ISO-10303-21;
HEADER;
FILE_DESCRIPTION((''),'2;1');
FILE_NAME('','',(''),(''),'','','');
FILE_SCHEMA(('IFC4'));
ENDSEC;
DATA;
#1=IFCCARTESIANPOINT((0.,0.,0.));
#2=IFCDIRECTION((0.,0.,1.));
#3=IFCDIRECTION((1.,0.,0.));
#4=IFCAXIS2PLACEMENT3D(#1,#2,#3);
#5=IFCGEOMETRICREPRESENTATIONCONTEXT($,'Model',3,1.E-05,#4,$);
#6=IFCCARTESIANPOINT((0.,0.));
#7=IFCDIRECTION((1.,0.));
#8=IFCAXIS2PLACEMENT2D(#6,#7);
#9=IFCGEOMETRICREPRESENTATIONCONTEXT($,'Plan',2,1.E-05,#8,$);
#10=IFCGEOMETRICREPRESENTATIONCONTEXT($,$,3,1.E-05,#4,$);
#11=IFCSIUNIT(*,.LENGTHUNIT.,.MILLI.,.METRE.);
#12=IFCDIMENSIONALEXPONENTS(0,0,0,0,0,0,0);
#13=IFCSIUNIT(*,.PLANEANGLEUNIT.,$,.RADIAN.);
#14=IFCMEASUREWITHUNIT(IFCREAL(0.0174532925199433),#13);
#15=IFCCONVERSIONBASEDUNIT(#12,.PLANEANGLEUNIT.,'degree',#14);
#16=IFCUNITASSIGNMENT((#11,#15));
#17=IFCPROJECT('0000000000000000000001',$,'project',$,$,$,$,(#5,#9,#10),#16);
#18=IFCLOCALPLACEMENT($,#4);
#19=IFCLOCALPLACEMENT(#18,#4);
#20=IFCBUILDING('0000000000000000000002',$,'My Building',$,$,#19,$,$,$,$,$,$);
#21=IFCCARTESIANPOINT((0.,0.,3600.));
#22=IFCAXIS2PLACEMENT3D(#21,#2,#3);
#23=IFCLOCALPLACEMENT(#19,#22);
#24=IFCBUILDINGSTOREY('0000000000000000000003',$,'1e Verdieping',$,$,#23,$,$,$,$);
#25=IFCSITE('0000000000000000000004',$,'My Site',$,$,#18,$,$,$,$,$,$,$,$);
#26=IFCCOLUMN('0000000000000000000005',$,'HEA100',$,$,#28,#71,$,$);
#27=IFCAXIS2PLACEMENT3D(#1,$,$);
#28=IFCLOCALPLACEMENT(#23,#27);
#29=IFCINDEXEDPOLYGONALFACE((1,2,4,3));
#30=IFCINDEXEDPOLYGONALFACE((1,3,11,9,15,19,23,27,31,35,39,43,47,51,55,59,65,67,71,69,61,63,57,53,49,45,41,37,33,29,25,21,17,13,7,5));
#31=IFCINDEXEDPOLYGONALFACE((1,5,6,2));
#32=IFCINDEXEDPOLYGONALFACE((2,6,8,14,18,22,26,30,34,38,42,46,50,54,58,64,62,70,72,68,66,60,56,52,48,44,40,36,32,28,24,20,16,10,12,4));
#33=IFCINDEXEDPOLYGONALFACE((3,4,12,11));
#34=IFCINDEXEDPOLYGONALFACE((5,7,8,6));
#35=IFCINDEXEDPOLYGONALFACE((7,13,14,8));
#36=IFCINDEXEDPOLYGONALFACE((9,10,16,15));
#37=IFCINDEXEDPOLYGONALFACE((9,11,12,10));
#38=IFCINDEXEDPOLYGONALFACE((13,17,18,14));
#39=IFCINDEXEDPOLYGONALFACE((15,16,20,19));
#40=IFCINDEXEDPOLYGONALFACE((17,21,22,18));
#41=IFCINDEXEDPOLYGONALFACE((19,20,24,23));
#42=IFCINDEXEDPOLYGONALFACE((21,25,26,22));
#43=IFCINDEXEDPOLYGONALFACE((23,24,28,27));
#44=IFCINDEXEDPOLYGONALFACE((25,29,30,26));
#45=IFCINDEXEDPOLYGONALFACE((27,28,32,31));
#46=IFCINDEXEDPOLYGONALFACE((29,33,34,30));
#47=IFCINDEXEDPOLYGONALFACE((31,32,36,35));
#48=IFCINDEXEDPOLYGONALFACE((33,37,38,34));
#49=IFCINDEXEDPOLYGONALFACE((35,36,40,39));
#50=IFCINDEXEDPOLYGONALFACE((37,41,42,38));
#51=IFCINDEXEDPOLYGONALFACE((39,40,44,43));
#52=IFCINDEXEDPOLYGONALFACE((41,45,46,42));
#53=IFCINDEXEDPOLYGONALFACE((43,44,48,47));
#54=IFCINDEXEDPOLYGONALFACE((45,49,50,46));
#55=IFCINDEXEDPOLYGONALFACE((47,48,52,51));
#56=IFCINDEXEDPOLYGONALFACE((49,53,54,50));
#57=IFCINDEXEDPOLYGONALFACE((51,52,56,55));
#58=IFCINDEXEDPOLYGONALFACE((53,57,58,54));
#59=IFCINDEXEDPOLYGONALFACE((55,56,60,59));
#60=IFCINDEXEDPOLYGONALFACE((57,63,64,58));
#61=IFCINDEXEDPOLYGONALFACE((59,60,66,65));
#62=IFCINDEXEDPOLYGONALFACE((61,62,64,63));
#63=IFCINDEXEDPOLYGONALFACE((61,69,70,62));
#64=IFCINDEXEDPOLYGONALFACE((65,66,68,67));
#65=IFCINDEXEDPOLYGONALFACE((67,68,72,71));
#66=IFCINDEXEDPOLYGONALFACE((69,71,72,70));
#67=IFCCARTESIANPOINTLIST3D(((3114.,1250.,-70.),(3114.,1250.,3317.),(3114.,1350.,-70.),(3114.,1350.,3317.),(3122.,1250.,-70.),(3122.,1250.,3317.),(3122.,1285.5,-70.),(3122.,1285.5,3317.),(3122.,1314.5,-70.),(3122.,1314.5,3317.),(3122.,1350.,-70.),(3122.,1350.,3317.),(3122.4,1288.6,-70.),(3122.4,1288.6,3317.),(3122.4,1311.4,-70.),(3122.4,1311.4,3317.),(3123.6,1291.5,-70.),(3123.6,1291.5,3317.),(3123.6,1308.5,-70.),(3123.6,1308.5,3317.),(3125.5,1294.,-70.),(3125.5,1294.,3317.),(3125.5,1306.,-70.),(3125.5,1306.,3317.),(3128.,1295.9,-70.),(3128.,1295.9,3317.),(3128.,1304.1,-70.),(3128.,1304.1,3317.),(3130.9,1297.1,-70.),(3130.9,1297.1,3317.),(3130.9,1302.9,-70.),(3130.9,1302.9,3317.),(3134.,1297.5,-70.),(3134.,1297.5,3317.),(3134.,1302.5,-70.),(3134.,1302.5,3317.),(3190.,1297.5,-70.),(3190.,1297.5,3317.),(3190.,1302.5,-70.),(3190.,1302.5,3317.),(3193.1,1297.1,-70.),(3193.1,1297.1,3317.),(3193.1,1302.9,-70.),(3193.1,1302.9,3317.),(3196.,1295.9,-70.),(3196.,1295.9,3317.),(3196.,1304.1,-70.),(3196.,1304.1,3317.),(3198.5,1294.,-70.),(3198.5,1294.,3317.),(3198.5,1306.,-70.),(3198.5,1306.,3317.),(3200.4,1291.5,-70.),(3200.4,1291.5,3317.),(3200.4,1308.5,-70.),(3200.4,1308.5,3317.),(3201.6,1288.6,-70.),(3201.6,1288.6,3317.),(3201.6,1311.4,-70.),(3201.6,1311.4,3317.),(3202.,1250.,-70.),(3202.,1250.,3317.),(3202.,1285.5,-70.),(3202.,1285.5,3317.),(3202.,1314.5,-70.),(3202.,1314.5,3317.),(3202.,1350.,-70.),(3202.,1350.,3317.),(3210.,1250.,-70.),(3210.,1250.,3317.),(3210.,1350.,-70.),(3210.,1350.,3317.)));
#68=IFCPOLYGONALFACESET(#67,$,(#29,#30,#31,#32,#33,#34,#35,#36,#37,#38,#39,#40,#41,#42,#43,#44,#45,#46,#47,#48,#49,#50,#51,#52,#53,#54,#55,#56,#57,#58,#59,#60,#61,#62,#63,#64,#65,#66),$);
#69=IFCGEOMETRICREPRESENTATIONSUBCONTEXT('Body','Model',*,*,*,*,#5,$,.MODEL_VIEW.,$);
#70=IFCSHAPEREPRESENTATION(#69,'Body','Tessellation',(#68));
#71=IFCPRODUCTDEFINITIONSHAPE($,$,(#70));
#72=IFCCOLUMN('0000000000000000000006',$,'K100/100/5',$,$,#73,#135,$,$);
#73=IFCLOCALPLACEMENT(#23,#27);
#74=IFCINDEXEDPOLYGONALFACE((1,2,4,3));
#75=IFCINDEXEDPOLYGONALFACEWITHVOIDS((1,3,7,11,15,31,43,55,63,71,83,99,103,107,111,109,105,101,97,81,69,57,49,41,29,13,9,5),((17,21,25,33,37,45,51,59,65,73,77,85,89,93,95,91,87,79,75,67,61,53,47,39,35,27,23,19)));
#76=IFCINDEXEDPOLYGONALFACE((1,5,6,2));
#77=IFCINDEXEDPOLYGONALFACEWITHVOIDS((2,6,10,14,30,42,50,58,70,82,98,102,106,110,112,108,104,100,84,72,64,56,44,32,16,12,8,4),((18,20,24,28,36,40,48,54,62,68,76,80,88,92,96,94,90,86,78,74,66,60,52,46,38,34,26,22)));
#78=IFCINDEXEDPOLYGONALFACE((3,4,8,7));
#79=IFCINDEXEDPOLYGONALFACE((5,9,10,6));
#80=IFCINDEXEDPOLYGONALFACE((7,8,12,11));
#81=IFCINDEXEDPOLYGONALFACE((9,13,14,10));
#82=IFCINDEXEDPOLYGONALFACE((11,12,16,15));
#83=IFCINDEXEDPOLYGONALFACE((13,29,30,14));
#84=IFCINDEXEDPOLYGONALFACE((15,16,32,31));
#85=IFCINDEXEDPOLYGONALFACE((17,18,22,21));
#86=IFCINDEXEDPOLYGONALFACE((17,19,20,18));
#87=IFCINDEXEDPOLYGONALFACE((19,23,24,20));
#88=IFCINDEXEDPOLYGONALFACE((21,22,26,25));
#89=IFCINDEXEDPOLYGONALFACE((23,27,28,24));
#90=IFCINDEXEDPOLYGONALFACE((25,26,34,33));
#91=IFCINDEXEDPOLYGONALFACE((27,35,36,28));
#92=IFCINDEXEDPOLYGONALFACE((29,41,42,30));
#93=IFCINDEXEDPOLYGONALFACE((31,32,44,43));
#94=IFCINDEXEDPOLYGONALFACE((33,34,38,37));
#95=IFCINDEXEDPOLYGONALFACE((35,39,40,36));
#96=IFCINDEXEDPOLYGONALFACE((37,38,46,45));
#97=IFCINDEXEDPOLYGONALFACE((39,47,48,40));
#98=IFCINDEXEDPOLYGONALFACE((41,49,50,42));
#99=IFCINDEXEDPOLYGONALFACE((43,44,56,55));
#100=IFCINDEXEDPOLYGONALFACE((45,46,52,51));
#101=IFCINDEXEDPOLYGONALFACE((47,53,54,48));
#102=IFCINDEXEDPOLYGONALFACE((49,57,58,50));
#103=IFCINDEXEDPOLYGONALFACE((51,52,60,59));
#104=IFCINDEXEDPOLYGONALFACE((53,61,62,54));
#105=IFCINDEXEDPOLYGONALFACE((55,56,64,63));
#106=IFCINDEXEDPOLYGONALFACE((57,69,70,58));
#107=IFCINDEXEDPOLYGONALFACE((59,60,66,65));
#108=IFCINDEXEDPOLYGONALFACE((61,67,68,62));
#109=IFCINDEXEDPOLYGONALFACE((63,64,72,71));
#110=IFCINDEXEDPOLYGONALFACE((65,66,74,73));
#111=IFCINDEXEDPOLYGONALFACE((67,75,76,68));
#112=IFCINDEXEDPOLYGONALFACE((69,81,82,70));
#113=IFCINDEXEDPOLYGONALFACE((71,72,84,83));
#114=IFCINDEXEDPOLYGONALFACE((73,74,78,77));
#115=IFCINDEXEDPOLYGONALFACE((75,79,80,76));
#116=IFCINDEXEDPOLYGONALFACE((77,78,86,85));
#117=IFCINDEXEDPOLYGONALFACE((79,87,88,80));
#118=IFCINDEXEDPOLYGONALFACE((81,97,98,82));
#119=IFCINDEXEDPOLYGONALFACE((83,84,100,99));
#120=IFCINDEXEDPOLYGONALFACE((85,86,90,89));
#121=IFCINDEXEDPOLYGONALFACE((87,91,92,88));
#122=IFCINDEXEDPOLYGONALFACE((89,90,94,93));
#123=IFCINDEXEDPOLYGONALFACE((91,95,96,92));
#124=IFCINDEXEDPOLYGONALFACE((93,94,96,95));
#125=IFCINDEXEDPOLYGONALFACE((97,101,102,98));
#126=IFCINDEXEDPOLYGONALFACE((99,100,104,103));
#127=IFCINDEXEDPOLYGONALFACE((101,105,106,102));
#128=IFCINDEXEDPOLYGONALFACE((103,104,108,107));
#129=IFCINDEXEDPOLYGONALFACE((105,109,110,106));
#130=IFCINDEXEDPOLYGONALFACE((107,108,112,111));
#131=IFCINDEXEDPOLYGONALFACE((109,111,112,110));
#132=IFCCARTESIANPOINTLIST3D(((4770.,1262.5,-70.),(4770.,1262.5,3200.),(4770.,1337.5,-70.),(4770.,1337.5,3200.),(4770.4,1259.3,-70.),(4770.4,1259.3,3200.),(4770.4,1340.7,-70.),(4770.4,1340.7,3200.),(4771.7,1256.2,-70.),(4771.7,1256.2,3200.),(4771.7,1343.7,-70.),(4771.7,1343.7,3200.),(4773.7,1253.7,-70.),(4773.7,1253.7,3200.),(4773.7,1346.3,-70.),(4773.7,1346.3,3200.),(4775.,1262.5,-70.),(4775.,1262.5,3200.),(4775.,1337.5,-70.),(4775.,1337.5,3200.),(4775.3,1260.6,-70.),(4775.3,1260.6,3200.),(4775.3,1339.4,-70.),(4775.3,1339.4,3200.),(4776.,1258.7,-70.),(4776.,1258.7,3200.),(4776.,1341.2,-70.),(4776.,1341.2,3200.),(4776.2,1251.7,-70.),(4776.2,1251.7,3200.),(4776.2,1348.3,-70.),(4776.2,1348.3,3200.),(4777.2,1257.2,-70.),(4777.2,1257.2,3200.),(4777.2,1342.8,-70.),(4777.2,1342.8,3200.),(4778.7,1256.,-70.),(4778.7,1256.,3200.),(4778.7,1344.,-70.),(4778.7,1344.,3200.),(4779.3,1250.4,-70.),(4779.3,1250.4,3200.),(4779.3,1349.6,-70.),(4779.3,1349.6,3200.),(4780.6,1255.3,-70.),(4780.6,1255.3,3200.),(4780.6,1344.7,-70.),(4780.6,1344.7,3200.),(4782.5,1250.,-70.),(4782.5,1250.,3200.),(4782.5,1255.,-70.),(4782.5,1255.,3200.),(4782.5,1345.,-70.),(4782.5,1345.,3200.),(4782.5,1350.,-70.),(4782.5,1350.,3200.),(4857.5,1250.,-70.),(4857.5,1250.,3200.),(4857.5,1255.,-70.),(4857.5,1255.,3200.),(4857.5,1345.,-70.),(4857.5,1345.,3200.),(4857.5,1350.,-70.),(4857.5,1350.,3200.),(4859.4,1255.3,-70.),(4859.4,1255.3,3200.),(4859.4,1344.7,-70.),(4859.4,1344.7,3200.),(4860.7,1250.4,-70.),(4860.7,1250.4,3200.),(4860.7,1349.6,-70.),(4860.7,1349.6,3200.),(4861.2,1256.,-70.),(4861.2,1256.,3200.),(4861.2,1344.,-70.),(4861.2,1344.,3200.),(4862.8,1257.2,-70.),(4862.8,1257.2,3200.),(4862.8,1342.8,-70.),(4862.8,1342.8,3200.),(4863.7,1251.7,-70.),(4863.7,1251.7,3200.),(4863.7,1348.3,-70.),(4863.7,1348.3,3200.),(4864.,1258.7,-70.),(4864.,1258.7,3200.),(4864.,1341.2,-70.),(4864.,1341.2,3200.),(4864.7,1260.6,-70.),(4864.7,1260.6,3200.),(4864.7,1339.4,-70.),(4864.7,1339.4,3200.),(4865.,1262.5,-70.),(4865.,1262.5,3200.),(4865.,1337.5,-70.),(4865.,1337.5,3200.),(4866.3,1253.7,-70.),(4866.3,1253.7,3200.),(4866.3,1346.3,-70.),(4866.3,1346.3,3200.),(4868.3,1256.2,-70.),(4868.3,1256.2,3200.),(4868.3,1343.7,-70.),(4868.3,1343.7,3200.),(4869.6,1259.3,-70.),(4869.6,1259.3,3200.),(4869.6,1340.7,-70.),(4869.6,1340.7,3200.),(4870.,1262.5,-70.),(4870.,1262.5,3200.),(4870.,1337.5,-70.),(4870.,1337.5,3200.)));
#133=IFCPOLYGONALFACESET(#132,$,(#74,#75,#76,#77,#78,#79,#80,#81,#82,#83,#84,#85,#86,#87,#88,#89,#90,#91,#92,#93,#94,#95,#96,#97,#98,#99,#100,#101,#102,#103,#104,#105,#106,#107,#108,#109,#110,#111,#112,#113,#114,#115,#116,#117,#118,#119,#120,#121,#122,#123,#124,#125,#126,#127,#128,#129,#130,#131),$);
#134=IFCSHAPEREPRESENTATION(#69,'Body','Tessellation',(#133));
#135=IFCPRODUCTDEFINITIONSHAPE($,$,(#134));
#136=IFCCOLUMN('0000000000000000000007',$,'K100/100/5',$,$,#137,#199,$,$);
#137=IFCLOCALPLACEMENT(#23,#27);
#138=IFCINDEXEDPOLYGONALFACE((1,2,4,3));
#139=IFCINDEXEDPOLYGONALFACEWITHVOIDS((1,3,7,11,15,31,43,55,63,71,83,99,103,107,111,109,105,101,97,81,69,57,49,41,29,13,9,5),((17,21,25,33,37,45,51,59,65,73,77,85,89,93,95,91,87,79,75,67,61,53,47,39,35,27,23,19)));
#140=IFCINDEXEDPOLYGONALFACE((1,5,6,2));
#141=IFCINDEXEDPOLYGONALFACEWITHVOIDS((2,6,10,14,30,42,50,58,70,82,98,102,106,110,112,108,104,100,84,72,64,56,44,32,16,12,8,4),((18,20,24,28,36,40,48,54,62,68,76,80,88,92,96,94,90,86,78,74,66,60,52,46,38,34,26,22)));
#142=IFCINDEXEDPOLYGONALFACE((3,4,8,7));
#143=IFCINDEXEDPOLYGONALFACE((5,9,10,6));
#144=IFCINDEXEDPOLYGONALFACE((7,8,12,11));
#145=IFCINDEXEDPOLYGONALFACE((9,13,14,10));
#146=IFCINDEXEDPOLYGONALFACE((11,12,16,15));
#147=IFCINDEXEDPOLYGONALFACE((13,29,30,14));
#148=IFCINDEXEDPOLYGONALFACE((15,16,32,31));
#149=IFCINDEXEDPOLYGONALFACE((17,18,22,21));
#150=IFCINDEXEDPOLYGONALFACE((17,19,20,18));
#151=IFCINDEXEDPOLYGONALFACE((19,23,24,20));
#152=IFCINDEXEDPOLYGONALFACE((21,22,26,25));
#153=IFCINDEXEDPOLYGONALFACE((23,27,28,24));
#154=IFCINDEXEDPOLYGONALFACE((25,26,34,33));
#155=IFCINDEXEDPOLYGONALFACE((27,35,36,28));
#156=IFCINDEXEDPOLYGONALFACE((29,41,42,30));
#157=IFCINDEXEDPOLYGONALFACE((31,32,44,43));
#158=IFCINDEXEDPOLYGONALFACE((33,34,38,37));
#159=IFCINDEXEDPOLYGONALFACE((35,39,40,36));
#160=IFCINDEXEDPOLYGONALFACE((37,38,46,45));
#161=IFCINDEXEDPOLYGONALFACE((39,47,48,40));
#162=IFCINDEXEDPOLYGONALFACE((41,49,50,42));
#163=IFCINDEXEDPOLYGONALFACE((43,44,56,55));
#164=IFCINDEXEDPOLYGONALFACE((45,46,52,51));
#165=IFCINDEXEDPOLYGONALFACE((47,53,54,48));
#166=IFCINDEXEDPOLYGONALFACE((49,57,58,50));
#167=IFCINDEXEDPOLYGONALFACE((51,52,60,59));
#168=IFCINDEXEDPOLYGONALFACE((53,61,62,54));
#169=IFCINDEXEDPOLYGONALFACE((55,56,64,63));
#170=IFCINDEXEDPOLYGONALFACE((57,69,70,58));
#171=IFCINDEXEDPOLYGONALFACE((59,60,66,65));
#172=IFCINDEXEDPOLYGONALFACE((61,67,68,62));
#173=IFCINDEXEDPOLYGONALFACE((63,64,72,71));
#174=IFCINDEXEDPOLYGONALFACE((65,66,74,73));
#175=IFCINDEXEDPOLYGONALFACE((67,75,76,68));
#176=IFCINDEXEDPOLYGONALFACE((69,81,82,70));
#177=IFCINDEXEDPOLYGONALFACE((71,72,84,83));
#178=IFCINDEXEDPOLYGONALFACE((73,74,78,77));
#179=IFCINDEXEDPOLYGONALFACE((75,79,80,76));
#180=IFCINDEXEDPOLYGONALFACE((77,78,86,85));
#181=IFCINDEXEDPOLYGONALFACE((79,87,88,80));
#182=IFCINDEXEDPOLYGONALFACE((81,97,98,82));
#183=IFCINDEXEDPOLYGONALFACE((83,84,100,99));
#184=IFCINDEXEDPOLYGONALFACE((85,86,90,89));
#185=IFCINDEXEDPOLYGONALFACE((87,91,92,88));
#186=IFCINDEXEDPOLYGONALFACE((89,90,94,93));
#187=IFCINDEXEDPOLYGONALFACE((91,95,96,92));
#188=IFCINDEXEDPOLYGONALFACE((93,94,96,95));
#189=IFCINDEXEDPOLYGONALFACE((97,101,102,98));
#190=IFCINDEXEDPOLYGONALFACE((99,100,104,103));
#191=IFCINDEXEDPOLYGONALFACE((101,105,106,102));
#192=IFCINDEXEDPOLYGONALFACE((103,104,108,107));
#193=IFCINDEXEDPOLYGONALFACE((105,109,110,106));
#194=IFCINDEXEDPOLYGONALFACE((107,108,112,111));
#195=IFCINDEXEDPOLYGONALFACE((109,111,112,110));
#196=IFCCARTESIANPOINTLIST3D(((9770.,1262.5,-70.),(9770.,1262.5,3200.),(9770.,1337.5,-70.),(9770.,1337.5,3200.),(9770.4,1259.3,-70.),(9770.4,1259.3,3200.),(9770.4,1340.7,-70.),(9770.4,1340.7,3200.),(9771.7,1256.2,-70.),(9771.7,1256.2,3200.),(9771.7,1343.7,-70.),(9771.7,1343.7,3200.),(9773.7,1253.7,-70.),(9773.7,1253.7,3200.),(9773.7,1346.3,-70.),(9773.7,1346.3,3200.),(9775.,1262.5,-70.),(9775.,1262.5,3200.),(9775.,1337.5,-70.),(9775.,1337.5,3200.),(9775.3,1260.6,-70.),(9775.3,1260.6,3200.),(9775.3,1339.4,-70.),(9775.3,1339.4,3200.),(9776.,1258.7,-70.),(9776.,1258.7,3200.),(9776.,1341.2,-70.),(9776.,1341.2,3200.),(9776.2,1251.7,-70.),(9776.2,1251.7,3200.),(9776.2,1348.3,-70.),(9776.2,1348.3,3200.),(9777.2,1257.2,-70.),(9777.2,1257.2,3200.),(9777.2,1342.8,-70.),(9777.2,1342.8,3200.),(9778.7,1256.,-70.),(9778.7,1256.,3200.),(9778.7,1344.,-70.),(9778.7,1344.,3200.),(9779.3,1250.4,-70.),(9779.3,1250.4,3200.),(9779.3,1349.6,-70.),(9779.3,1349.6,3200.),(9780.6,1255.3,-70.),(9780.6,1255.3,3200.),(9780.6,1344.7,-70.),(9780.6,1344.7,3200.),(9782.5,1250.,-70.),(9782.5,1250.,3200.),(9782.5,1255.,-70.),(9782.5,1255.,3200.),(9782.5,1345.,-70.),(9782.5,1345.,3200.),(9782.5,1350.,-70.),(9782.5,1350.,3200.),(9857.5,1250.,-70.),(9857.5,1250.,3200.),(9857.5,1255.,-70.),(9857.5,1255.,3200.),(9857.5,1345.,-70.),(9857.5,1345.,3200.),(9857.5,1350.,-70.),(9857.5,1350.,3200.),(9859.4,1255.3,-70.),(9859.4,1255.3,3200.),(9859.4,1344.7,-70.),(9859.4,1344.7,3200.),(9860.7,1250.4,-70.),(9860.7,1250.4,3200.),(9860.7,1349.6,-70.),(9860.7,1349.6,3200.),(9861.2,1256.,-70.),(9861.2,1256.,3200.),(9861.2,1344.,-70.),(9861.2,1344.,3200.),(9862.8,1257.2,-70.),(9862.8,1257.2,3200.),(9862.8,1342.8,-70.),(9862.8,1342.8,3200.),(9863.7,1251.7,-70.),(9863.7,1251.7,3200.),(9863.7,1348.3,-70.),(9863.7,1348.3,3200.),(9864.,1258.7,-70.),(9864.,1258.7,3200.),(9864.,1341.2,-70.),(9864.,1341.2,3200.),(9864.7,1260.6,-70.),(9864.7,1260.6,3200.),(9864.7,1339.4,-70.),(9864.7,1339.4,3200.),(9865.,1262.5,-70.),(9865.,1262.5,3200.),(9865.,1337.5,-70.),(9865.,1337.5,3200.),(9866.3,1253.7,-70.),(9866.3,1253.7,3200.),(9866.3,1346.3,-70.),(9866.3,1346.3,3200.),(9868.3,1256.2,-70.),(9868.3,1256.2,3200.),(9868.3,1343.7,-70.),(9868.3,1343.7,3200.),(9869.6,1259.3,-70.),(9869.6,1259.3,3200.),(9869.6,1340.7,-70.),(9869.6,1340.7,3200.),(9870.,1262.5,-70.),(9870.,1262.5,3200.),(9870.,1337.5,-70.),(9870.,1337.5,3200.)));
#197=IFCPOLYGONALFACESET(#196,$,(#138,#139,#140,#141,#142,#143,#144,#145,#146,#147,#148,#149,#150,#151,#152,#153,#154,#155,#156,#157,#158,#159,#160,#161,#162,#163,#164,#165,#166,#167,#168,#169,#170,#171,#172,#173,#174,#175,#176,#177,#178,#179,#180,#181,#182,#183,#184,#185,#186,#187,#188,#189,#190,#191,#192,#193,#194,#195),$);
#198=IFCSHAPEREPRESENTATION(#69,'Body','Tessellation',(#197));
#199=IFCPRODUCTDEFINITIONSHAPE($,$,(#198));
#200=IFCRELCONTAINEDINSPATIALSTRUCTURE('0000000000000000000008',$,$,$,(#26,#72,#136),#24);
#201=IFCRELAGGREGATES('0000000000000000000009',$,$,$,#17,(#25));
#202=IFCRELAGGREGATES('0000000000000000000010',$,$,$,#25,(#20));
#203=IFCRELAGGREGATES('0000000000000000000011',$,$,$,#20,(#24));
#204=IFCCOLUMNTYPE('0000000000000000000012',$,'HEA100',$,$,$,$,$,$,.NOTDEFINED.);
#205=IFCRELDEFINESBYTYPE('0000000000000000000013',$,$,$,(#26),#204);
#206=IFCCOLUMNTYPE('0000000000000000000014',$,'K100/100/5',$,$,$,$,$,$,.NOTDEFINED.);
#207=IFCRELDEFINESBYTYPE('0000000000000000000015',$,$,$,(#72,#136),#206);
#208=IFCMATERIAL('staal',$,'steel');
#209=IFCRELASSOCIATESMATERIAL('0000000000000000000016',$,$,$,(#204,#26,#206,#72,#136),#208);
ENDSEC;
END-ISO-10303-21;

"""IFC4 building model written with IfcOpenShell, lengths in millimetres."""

from ifc_helpers import new_model, entity, si_unit, converted_unit, frame, origin_with_axes, origin_2d_with_axis, place, context, subcontext, project, spatial, hollow_rectangle, i_section, extrude, material, material_profile, profile_set, profile_usage, type_object, element, save


model = new_model("IFC4")

# Units and contexts
model_context = context("Model", 3, precision=1e-05, world=origin_with_axes())
plan_context = context("Plan", 2, precision=1e-05, world=origin_2d_with_axis())
context_of_model = context(None, 3, precision=1e-05, world=origin_with_axes())
body_context = subcontext(model_context, "Body", "Model", "MODEL_VIEW")
ifc_project = project(units=[si_unit("LENGTHUNIT", "METRE", prefix="MILLI"), converted_unit("PLANEANGLEUNIT", "degree", entity("IfcReal", 0.0174532925199433), si_unit("PLANEANGLEUNIT", "RADIAN"), dimensions=[0, 0, 0, 0, 0, 0, 0])], contexts=[model_context, plan_context, context_of_model])

# Site, building, storey
site_placement = place(None, origin_with_axes())
site = spatial("IfcSite", under=ifc_project, at=site_placement, Name="My Site")
building_placement = place(site_placement, origin_with_axes())
building = spatial("IfcBuilding", under=site, at=building_placement, Name="My Building")
storey_placement = place(building_placement, frame((0.0, 0.0, 3600.0), z_axis=(0.0, 0.0, 1.0), x_axis=(1.0, 0.0, 0.0)))
storey = spatial("IfcBuildingStorey", under=building, at=storey_placement, Name="1e Verdieping")

# Columns
ifc_material_1 = material(Name="staal", Category="steel")
ifc_material_profile_1 = material_profile(ifc_material_1, i_section(OverallWidth=100.0, OverallDepth=96.0, WebThickness=5.0, FlangeThickness=8.0, FilletRadius=12.0))
ifc_profile_set_1 = profile_set([ifc_material_profile_1], Name="HEA100")
column_type_1 = type_object("IfcColumnType", Name="HEA100", PredefinedType="NOTDEFINED", material=ifc_profile_set_1)
ifc_profile_usage_1 = profile_usage(ifc_profile_set_1)
column_1_placement = place(storey_placement, frame((3162.0, 1300.0, -70.0), z_axis=(0.0, 0.0, 1.0), x_axis=(0.0, 1.0, 0.0)))
element("IfcColumn", 1, at=column_1_placement, inside=storey, type_object=column_type_1, material=ifc_profile_usage_1, Name="HEA100", context=body_context, shape_type="SweptSolid", body=[
    extrude(i_section(OverallWidth=100.0, OverallDepth=96.0, WebThickness=5.0, FlangeThickness=8.0, FilletRadius=12.0), origin_with_axes(), (0.0, 0.0, 1.0), 3387.0),
])
ifc_material_profile_2 = material_profile(ifc_material_1, hollow_rectangle(XDim=100.0, YDim=100.0, WallThickness=5.0, InnerFilletRadius=7.5, OuterFilletRadius=12.5))
ifc_profile_set_2 = profile_set([ifc_material_profile_2], Name="K100/100/5")
ifc_profile_usage_2 = profile_usage(ifc_profile_set_2, cardinal=5)
column_type_2 = type_object("IfcColumnType", Name="K100/100/5", PredefinedType="NOTDEFINED", material=ifc_profile_set_2)
column_2_placement = place(storey_placement, frame((4820.0, 1300.0, -70.0), z_axis=(0.0, 0.0, 1.0), x_axis=(1.0, 0.0, 0.0)))
element("IfcColumn", 2, at=column_2_placement, inside=storey, type_object=column_type_2, material=ifc_profile_usage_2, Name="K100/100/5", context=body_context, shape_type="SweptSolid", body=[
    extrude(hollow_rectangle(XDim=100.0, YDim=100.0, WallThickness=5.0, InnerFilletRadius=7.5, OuterFilletRadius=12.5), origin_with_axes(), (0.0, 0.0, 1.0), 3270.0),
])
ifc_profile_usage_3 = profile_usage(ifc_profile_set_2, cardinal=5)
column_3_placement = place(storey_placement, frame((9820.0, 1300.0, -70.0), z_axis=(0.0, 0.0, 1.0), x_axis=(1.0, 0.0, 0.0)))
element("IfcColumn", 3, at=column_3_placement, inside=storey, type_object=column_type_2, material=ifc_profile_usage_3, Name="K100/100/5", context=body_context, shape_type="SweptSolid", body=[
    extrude(hollow_rectangle(XDim=100.0, YDim=100.0, WallThickness=5.0, InnerFilletRadius=7.5, OuterFilletRadius=12.5), origin_with_axes(), (0.0, 0.0, 1.0), 3270.0),
])

save(model, "model.ifc")
